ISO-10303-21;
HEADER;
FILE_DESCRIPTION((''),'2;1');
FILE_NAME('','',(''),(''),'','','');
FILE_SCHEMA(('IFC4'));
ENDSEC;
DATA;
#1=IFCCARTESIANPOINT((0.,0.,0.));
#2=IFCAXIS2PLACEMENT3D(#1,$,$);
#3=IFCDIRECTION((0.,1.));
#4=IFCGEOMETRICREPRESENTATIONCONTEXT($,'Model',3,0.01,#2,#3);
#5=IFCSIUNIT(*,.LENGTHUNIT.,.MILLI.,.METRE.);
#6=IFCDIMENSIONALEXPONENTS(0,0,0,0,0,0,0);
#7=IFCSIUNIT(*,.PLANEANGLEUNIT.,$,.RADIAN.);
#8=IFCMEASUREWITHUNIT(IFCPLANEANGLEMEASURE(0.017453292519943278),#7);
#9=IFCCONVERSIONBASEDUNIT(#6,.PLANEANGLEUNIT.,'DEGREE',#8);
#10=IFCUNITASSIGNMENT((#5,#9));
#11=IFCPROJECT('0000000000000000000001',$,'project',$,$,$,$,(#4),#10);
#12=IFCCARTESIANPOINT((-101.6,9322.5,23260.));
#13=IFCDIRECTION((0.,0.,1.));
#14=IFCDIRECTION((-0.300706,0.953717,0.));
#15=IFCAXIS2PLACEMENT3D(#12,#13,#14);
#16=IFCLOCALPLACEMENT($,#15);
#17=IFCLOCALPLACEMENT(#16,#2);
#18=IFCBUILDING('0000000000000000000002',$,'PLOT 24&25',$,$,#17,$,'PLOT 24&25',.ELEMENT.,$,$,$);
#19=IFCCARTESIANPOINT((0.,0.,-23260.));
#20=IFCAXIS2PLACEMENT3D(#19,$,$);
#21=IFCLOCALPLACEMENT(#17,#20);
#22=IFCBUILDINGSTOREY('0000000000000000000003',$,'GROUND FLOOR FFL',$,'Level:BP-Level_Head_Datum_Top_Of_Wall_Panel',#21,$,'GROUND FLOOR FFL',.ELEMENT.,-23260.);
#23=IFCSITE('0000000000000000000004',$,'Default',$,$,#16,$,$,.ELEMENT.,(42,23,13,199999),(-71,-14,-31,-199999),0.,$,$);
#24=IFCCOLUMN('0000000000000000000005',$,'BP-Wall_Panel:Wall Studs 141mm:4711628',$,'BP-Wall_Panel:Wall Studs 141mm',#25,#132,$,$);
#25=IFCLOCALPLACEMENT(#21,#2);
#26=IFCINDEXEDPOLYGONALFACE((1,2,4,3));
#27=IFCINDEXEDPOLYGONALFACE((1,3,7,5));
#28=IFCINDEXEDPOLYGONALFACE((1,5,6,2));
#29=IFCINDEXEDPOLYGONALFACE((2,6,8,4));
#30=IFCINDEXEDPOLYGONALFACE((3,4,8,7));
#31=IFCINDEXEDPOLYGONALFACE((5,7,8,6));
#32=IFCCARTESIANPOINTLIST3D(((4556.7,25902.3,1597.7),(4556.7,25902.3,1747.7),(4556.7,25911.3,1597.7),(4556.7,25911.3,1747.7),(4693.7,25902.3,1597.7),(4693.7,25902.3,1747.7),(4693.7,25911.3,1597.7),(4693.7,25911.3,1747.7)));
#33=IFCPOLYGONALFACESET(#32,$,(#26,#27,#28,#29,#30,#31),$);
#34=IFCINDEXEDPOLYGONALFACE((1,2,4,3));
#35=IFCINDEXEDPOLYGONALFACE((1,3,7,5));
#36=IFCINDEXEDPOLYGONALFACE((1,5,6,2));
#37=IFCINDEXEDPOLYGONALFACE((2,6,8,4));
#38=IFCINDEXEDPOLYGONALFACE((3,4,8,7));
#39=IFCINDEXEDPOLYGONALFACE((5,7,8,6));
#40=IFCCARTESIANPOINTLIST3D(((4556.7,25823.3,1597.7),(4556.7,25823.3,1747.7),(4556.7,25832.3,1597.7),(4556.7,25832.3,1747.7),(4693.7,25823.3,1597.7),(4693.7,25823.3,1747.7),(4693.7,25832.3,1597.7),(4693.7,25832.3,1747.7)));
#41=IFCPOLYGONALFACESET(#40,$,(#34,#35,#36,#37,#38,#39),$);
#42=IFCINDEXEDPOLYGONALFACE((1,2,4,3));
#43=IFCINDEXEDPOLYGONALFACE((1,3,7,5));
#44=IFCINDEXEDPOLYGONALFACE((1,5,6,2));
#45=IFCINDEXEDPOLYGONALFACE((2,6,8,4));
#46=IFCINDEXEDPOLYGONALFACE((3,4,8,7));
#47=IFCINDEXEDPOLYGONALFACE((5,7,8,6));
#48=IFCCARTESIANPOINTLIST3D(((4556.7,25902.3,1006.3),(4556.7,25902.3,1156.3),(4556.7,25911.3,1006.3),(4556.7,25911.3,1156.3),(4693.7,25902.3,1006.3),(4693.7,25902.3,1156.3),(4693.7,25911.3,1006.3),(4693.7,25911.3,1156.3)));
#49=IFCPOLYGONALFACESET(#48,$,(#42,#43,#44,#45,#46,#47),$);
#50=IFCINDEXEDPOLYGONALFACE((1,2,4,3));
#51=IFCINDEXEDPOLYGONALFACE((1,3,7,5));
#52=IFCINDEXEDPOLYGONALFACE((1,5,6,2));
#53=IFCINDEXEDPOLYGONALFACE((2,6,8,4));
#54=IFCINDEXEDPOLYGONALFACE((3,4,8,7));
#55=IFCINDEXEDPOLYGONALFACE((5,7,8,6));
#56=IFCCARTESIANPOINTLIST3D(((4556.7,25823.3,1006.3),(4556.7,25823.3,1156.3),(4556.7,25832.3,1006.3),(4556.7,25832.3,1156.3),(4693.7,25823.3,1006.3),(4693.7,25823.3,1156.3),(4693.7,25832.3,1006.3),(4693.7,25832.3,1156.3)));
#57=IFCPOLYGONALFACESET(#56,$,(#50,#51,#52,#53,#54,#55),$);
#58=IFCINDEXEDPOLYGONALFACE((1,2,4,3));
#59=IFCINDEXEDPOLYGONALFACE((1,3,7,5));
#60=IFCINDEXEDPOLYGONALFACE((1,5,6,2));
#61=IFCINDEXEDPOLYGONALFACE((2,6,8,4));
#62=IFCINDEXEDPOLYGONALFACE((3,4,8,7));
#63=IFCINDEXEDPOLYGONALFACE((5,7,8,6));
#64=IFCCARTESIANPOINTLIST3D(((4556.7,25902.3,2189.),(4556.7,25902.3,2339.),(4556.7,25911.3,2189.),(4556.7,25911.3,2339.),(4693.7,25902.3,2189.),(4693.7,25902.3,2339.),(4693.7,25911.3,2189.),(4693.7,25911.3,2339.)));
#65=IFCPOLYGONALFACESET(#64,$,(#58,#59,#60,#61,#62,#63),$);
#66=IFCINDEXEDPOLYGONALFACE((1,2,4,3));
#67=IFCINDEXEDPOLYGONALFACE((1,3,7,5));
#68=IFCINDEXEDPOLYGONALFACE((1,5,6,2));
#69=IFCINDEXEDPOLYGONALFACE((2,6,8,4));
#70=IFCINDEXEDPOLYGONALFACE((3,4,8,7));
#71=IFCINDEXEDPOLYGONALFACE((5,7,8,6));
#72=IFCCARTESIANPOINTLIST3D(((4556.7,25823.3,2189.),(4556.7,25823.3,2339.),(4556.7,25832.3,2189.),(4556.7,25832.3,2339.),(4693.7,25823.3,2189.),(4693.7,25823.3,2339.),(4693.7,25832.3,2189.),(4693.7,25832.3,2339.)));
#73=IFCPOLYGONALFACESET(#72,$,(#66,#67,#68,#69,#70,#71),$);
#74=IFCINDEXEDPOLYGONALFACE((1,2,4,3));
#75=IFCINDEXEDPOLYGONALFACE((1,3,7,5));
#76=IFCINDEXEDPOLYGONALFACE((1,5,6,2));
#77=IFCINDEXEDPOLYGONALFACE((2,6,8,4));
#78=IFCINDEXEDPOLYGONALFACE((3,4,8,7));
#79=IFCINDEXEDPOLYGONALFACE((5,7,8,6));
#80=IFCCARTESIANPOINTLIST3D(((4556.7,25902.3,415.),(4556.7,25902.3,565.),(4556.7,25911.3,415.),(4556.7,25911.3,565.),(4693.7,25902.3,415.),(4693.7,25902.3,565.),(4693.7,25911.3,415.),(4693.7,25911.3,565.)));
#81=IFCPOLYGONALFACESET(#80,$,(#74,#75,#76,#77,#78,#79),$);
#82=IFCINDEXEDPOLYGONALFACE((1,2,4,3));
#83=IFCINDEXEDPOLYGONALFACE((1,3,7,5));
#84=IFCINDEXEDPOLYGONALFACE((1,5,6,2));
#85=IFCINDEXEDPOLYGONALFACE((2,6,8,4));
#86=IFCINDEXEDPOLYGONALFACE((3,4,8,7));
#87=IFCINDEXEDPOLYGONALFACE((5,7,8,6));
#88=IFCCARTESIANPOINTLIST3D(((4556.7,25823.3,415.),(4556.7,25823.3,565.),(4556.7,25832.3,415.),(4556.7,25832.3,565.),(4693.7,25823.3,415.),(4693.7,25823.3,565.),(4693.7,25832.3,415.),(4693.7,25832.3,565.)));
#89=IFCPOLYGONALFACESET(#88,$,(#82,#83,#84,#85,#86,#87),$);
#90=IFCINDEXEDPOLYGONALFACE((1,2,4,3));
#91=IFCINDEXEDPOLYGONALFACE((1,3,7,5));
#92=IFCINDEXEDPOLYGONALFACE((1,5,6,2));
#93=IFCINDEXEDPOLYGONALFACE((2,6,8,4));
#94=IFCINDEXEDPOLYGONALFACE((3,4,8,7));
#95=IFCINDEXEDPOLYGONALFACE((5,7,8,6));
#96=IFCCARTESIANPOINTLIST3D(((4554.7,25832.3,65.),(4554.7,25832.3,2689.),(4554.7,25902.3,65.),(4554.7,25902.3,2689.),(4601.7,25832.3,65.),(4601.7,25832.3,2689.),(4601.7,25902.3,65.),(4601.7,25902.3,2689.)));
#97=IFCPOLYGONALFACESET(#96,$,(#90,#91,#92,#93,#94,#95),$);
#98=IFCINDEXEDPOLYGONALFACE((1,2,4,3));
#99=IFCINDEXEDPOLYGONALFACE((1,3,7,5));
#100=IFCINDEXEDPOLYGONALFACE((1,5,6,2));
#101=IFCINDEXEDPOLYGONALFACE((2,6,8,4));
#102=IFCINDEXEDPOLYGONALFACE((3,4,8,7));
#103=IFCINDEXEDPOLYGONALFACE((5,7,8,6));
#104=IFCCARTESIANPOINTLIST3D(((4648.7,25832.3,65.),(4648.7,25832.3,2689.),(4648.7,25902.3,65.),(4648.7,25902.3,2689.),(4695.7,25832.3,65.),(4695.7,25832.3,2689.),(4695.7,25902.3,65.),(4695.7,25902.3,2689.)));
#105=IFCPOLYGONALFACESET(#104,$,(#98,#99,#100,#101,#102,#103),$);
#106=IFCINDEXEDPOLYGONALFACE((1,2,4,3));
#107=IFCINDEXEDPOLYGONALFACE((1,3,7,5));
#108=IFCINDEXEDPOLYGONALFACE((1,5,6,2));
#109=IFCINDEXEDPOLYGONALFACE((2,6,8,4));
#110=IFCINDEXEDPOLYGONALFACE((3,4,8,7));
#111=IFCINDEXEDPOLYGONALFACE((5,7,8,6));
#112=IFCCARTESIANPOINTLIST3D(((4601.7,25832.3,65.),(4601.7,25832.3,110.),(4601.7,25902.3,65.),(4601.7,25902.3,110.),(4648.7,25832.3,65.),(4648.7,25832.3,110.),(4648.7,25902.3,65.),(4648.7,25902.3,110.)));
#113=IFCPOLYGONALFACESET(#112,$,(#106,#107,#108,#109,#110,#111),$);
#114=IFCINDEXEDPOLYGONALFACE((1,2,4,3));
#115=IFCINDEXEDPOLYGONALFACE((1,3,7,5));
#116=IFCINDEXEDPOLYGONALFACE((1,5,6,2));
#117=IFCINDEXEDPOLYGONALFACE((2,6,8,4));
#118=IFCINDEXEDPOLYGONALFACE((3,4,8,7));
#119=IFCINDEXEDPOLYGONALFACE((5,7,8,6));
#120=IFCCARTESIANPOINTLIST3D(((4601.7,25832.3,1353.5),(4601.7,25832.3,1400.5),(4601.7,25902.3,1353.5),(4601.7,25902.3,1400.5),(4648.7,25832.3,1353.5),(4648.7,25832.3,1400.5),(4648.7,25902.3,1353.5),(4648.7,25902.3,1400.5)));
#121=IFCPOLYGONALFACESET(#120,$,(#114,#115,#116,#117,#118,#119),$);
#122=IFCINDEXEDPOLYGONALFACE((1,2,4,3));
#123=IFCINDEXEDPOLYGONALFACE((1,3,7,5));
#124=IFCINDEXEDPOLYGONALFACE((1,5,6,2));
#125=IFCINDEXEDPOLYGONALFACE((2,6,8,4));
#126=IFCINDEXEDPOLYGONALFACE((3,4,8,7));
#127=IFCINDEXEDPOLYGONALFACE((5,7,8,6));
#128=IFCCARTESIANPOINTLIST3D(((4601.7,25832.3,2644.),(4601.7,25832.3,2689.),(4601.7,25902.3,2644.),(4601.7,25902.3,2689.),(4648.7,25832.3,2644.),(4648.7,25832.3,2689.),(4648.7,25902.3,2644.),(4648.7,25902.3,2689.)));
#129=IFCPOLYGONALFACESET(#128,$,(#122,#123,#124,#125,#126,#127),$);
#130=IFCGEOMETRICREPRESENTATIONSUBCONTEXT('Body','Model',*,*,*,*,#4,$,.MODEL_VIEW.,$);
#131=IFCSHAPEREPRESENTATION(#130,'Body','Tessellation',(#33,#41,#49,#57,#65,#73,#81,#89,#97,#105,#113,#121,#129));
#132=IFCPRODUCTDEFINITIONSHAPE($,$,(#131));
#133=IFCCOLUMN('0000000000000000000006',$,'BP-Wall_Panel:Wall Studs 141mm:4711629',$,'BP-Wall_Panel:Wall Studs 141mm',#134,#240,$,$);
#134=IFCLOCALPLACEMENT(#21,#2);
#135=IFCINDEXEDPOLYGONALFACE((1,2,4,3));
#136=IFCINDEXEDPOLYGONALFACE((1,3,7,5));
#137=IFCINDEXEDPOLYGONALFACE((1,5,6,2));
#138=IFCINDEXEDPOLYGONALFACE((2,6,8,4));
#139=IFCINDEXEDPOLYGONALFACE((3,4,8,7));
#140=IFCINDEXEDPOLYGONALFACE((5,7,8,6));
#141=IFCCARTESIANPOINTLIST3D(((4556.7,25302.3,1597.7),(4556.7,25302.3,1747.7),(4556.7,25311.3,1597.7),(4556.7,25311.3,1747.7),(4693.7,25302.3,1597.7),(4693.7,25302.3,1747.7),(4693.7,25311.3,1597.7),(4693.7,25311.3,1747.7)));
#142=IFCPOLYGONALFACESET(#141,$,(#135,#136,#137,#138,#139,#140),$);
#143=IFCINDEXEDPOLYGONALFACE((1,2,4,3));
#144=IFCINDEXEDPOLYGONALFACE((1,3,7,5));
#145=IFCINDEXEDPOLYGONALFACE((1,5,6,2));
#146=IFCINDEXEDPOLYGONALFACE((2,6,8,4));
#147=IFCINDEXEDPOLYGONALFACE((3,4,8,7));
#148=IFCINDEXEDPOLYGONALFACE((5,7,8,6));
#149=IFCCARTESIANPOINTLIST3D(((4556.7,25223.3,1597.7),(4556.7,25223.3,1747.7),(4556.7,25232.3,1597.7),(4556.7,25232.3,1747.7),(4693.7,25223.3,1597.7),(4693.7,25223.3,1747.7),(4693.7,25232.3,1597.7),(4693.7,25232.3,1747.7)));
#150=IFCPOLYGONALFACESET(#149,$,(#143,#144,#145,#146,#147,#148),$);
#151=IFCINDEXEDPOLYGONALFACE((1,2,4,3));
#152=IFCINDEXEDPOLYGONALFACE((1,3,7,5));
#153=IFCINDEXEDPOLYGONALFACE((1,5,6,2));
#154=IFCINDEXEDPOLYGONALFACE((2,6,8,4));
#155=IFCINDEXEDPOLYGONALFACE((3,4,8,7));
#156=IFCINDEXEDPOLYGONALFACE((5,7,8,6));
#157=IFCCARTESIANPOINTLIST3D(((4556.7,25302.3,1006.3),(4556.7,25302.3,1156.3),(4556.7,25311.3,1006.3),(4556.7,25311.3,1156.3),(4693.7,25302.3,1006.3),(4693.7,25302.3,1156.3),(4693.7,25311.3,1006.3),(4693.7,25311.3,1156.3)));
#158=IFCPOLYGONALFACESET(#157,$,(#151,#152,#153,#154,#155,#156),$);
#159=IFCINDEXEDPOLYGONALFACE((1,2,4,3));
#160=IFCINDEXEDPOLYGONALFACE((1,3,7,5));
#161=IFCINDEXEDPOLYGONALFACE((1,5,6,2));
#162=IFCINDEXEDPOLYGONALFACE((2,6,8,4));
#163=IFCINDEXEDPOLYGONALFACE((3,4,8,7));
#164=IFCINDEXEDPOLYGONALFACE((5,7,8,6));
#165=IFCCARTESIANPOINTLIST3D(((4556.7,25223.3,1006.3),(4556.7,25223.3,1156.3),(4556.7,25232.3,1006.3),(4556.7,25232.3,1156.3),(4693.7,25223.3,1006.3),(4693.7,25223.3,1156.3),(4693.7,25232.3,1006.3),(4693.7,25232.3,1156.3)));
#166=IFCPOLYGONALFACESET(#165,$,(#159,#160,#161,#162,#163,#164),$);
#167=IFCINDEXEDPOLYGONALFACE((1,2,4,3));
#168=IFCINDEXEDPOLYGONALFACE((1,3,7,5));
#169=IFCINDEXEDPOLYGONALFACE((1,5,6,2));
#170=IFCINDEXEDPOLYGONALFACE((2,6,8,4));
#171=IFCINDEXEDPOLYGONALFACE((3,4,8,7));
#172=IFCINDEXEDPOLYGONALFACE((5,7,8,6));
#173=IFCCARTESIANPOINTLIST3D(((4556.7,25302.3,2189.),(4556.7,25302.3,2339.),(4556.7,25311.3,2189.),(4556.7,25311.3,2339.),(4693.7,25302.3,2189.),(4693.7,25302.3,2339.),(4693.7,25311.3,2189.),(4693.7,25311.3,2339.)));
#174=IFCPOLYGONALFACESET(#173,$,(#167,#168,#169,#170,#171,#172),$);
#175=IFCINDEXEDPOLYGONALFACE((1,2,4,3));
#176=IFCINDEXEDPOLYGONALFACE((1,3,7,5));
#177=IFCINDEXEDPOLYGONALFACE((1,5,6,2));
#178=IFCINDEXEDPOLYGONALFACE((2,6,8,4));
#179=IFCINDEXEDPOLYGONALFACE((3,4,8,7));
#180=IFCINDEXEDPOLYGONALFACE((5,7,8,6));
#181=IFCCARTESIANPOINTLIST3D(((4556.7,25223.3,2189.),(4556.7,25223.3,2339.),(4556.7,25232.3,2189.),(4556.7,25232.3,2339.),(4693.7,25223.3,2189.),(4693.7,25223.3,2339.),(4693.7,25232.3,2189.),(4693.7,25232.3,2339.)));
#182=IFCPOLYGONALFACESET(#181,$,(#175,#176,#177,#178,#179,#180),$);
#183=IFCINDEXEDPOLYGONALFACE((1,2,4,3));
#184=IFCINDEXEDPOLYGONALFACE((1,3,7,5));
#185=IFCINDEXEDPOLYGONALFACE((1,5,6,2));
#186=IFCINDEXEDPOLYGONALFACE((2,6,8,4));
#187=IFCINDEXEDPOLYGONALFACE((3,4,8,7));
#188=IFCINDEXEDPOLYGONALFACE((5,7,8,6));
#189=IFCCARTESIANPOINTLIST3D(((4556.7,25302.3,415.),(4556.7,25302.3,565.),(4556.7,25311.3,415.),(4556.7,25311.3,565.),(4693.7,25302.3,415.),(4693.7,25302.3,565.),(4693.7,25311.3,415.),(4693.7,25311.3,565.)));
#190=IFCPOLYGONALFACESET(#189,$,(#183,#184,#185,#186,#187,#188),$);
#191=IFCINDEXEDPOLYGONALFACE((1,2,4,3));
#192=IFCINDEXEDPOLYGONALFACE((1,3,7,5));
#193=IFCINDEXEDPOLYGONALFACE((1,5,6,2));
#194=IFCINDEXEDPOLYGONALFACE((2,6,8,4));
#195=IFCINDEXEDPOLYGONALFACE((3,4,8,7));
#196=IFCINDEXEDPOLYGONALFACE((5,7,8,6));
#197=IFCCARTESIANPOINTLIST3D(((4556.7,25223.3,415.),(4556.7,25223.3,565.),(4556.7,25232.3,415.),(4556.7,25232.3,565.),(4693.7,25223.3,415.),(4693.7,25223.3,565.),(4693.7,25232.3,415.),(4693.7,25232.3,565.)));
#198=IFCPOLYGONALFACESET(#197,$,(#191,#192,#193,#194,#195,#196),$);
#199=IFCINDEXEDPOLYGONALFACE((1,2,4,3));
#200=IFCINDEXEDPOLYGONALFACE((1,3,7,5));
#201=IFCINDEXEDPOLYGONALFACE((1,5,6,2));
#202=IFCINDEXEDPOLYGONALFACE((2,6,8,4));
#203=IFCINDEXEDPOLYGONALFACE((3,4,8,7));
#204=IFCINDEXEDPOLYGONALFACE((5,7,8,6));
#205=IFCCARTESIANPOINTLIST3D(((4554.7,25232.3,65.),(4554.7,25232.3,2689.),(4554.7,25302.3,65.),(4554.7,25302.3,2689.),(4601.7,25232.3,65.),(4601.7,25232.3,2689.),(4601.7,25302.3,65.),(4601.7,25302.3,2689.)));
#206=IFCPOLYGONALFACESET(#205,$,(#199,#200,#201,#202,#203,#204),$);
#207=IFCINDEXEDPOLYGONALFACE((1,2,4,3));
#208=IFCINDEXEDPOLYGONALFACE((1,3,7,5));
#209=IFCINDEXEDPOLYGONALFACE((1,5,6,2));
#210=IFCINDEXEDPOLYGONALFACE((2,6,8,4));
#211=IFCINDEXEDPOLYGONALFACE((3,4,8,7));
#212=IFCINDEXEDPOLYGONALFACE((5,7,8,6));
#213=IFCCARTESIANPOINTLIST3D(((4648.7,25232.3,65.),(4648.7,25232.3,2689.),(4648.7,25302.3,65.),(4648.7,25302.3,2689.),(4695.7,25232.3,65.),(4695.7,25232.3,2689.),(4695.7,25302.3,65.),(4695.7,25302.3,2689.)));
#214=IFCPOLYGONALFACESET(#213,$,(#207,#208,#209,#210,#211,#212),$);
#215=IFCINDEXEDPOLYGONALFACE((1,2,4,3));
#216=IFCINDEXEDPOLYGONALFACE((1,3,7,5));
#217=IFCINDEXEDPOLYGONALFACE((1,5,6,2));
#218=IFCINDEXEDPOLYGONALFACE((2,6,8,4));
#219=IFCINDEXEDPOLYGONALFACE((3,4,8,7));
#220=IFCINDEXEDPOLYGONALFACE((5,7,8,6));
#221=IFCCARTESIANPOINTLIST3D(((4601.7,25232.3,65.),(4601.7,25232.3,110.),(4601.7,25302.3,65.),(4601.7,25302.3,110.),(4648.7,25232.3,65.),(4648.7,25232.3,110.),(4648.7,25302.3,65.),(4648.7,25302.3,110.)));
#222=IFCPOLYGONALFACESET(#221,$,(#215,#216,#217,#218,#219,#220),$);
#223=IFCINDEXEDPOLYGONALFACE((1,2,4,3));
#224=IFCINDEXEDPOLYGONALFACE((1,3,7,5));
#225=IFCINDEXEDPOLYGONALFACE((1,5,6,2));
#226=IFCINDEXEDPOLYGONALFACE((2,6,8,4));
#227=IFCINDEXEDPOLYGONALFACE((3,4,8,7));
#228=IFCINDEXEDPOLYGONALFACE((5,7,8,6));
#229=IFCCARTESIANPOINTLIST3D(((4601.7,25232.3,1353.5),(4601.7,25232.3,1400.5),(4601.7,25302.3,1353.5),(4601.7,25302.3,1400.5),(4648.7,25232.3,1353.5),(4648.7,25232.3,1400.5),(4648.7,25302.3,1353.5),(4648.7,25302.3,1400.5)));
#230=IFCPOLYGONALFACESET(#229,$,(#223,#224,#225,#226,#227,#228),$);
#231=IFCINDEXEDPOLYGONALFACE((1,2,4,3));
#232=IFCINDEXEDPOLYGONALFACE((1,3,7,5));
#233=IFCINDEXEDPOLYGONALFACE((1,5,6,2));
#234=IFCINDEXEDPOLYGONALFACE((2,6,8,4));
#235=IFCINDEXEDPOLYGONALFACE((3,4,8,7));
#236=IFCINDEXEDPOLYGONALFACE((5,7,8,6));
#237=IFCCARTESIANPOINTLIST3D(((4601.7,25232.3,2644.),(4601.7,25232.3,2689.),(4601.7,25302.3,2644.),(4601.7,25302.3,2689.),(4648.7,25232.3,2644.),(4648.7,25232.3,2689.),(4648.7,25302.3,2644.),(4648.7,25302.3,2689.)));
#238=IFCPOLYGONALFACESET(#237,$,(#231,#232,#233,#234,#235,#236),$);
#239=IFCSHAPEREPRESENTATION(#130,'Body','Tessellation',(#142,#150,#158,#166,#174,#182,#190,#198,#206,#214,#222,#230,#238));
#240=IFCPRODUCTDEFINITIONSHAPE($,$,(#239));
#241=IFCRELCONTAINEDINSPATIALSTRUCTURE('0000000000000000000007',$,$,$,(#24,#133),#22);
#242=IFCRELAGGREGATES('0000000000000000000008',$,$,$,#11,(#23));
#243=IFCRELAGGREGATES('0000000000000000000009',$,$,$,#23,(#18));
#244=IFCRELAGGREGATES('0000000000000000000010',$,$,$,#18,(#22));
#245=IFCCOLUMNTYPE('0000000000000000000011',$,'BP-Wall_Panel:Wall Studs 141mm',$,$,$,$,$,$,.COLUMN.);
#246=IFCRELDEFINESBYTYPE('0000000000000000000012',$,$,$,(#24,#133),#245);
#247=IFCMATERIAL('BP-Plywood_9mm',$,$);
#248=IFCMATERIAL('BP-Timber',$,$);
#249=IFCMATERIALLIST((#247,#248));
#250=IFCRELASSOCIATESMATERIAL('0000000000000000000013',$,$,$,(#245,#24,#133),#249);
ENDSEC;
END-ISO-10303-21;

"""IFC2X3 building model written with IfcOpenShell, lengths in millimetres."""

from ifc_helpers import new_model, entity, si_unit, converted_unit, direction, frame, origin, origin_2d_with_axis, place, context, subcontext, project, spatial, rectangle, extrude, source, transform, mapped, material, material_list, type_object, type_shapes, element, save


model = new_model("IFC2X3")

# Units and contexts
model_context = context("Model", 3, precision=0.01, world=origin(), true_north=direction((0.0, 1.0)))
body_context = subcontext(model_context, "Body", "Model", "MODEL_VIEW")
ifc_project = project(units=[si_unit("LENGTHUNIT", "METRE", prefix="MILLI"), converted_unit("PLANEANGLEUNIT", "DEGREE", entity("IfcPlaneAngleMeasure", 0.017453292519943278), si_unit("PLANEANGLEUNIT", "RADIAN"), dimensions=[0, 0, 0, 0, 0, 0, 0])], contexts=[model_context])

# Site, building, storey
site_placement = place(None, frame((-101.6, 9322.5, 23260.0), z_axis=(0.0, 0.0, 1.0), x_axis=(-0.300706, 0.953717, 0.0)))
site = spatial("IfcSite", under=ifc_project, at=site_placement, Name="Default", CompositionType="ELEMENT", RefLatitude=(42, 23, 13, 199999), RefLongitude=(-71, -14, -31, -199999), RefElevation=0.0)
building_placement = place(site_placement, origin())
building = spatial("IfcBuilding", under=site, at=building_placement, Name="PLOT 24&25", LongName="PLOT 24&25", CompositionType="ELEMENT")
storey_placement = place(building_placement, frame((0.0, 0.0, -23260.0)))
storey = spatial("IfcBuildingStorey", under=building, at=storey_placement, Name="GROUND FLOOR FFL", ObjectType="Level:BP-Level_Head_Datum_Top_Of_Wall_Panel", LongName="GROUND FLOOR FFL", CompositionType="ELEMENT", Elevation=-23260.0)

# Columns
ifc_material_1 = material(Name="BP-Plywood_9mm")
ifc_material_2 = material(Name="BP-Timber")
ifc_material_list = material_list([ifc_material_1, ifc_material_2])
column_type_1 = type_object("IfcColumnType", Name="BP-Wall_Panel:Wall Studs 141mm", PredefinedType="COLUMN", material=ifc_material_list)
shared_shape_1 = source(origin(), body_context, "Body", "SweptSolid", [
    extrude(rectangle(XDim=9.0, YDim=137.0, at=origin_2d_with_axis()), frame((39.5, 0.0, -21662.3)), (0.0, 0.0, 1.0), 150.0),
    extrude(rectangle(XDim=137.0, YDim=9.0, at=origin_2d_with_axis()), frame((-39.5, 0.0, -21662.3), z_axis=(0.0, 0.0, 1.0), x_axis=(0.0, 1.0, 0.0)), (0.0, 0.0, 1.0), 150.0),
    extrude(rectangle(XDim=9.0, YDim=137.0, at=origin_2d_with_axis()), frame((39.5, 0.0, -22253.7)), (0.0, 0.0, 1.0), 150.0),
    extrude(rectangle(XDim=137.0, YDim=9.0, at=origin_2d_with_axis()), frame((-39.5, 0.0, -22253.7), z_axis=(0.0, 0.0, 1.0), x_axis=(0.0, 1.0, 0.0)), (0.0, 0.0, 1.0), 150.0),
    extrude(rectangle(XDim=9.0, YDim=137.0, at=origin_2d_with_axis()), frame((39.5, 0.0, -21071.0)), (0.0, 0.0, 1.0), 150.0),
    extrude(rectangle(XDim=137.0, YDim=9.0, at=origin_2d_with_axis()), frame((-39.5, 0.0, -21071.0), z_axis=(0.0, 0.0, 1.0), x_axis=(0.0, 1.0, 0.0)), (0.0, 0.0, 1.0), 150.0),
    extrude(rectangle(XDim=9.0, YDim=137.0, at=origin_2d_with_axis()), frame((39.5, 0.0, -22845.0)), (0.0, 0.0, 1.0), 150.0),
    extrude(rectangle(XDim=137.0, YDim=9.0, at=origin_2d_with_axis()), frame((-39.5, 0.0, -22845.0), z_axis=(0.0, 0.0, 1.0), x_axis=(0.0, 1.0, 0.0)), (0.0, 0.0, 1.0), 150.0),
    extrude(rectangle(XDim=47.0, YDim=70.0, at=origin_2d_with_axis()), frame((0.0, 47.0, -23195.0), z_axis=(0.0, 0.0, 1.0), x_axis=(0.0, 1.0, 0.0)), (0.0, 0.0, 1.0), 2624.0),
    extrude(rectangle(XDim=47.0, YDim=70.0, at=origin_2d_with_axis()), frame((0.0, -47.0, -23195.0), z_axis=(0.0, 0.0, 1.0), x_axis=(0.0, 1.0, 0.0)), (0.0, 0.0, 1.0), 2624.0),
    extrude(rectangle(XDim=70.0, YDim=47.0, at=origin_2d_with_axis()), frame((0.0, 0.0, -23195.0)), (0.0, 0.0, 1.0), 45.0),
    extrude(rectangle(XDim=70.0, YDim=47.0, at=origin_2d_with_axis()), frame((0.0, 0.0, -21906.5)), (0.0, 0.0, 1.0), 47.0),
    extrude(rectangle(XDim=70.0, YDim=47.0, at=origin_2d_with_axis()), frame((0.0, 0.0, -20616.0)), (0.0, 0.0, 1.0), 45.0),
])
type_shapes(column_type_1, [shared_shape_1])
for number, where, z_axis, x_axis, name in (
    (1, (4625.2, 25867.3, 23260.0), (0.0, 0.0, 1.0), (0.0, 1.0, 0.0), "BP-Wall_Panel:Wall Studs 141mm:4711628"),
    (2, (4625.2, 25267.3, 23260.0), (0.0, 0.0, 1.0), (0.0, 1.0, 0.0), "BP-Wall_Panel:Wall Studs 141mm:4711629"),
):
    element("IfcColumn", number, at=place(storey_placement, frame(where, z_axis=z_axis, x_axis=x_axis)), inside=storey, type_object=column_type_1, material=ifc_material_list, Name=name, ObjectType="BP-Wall_Panel:Wall Studs 141mm", context=body_context, shape_type="MappedRepresentation", body=[
        mapped(shared_shape_1, transform((0.0, 0.0, 0.0), scale=1.0)),
    ])

save(model, "model.ifc")
